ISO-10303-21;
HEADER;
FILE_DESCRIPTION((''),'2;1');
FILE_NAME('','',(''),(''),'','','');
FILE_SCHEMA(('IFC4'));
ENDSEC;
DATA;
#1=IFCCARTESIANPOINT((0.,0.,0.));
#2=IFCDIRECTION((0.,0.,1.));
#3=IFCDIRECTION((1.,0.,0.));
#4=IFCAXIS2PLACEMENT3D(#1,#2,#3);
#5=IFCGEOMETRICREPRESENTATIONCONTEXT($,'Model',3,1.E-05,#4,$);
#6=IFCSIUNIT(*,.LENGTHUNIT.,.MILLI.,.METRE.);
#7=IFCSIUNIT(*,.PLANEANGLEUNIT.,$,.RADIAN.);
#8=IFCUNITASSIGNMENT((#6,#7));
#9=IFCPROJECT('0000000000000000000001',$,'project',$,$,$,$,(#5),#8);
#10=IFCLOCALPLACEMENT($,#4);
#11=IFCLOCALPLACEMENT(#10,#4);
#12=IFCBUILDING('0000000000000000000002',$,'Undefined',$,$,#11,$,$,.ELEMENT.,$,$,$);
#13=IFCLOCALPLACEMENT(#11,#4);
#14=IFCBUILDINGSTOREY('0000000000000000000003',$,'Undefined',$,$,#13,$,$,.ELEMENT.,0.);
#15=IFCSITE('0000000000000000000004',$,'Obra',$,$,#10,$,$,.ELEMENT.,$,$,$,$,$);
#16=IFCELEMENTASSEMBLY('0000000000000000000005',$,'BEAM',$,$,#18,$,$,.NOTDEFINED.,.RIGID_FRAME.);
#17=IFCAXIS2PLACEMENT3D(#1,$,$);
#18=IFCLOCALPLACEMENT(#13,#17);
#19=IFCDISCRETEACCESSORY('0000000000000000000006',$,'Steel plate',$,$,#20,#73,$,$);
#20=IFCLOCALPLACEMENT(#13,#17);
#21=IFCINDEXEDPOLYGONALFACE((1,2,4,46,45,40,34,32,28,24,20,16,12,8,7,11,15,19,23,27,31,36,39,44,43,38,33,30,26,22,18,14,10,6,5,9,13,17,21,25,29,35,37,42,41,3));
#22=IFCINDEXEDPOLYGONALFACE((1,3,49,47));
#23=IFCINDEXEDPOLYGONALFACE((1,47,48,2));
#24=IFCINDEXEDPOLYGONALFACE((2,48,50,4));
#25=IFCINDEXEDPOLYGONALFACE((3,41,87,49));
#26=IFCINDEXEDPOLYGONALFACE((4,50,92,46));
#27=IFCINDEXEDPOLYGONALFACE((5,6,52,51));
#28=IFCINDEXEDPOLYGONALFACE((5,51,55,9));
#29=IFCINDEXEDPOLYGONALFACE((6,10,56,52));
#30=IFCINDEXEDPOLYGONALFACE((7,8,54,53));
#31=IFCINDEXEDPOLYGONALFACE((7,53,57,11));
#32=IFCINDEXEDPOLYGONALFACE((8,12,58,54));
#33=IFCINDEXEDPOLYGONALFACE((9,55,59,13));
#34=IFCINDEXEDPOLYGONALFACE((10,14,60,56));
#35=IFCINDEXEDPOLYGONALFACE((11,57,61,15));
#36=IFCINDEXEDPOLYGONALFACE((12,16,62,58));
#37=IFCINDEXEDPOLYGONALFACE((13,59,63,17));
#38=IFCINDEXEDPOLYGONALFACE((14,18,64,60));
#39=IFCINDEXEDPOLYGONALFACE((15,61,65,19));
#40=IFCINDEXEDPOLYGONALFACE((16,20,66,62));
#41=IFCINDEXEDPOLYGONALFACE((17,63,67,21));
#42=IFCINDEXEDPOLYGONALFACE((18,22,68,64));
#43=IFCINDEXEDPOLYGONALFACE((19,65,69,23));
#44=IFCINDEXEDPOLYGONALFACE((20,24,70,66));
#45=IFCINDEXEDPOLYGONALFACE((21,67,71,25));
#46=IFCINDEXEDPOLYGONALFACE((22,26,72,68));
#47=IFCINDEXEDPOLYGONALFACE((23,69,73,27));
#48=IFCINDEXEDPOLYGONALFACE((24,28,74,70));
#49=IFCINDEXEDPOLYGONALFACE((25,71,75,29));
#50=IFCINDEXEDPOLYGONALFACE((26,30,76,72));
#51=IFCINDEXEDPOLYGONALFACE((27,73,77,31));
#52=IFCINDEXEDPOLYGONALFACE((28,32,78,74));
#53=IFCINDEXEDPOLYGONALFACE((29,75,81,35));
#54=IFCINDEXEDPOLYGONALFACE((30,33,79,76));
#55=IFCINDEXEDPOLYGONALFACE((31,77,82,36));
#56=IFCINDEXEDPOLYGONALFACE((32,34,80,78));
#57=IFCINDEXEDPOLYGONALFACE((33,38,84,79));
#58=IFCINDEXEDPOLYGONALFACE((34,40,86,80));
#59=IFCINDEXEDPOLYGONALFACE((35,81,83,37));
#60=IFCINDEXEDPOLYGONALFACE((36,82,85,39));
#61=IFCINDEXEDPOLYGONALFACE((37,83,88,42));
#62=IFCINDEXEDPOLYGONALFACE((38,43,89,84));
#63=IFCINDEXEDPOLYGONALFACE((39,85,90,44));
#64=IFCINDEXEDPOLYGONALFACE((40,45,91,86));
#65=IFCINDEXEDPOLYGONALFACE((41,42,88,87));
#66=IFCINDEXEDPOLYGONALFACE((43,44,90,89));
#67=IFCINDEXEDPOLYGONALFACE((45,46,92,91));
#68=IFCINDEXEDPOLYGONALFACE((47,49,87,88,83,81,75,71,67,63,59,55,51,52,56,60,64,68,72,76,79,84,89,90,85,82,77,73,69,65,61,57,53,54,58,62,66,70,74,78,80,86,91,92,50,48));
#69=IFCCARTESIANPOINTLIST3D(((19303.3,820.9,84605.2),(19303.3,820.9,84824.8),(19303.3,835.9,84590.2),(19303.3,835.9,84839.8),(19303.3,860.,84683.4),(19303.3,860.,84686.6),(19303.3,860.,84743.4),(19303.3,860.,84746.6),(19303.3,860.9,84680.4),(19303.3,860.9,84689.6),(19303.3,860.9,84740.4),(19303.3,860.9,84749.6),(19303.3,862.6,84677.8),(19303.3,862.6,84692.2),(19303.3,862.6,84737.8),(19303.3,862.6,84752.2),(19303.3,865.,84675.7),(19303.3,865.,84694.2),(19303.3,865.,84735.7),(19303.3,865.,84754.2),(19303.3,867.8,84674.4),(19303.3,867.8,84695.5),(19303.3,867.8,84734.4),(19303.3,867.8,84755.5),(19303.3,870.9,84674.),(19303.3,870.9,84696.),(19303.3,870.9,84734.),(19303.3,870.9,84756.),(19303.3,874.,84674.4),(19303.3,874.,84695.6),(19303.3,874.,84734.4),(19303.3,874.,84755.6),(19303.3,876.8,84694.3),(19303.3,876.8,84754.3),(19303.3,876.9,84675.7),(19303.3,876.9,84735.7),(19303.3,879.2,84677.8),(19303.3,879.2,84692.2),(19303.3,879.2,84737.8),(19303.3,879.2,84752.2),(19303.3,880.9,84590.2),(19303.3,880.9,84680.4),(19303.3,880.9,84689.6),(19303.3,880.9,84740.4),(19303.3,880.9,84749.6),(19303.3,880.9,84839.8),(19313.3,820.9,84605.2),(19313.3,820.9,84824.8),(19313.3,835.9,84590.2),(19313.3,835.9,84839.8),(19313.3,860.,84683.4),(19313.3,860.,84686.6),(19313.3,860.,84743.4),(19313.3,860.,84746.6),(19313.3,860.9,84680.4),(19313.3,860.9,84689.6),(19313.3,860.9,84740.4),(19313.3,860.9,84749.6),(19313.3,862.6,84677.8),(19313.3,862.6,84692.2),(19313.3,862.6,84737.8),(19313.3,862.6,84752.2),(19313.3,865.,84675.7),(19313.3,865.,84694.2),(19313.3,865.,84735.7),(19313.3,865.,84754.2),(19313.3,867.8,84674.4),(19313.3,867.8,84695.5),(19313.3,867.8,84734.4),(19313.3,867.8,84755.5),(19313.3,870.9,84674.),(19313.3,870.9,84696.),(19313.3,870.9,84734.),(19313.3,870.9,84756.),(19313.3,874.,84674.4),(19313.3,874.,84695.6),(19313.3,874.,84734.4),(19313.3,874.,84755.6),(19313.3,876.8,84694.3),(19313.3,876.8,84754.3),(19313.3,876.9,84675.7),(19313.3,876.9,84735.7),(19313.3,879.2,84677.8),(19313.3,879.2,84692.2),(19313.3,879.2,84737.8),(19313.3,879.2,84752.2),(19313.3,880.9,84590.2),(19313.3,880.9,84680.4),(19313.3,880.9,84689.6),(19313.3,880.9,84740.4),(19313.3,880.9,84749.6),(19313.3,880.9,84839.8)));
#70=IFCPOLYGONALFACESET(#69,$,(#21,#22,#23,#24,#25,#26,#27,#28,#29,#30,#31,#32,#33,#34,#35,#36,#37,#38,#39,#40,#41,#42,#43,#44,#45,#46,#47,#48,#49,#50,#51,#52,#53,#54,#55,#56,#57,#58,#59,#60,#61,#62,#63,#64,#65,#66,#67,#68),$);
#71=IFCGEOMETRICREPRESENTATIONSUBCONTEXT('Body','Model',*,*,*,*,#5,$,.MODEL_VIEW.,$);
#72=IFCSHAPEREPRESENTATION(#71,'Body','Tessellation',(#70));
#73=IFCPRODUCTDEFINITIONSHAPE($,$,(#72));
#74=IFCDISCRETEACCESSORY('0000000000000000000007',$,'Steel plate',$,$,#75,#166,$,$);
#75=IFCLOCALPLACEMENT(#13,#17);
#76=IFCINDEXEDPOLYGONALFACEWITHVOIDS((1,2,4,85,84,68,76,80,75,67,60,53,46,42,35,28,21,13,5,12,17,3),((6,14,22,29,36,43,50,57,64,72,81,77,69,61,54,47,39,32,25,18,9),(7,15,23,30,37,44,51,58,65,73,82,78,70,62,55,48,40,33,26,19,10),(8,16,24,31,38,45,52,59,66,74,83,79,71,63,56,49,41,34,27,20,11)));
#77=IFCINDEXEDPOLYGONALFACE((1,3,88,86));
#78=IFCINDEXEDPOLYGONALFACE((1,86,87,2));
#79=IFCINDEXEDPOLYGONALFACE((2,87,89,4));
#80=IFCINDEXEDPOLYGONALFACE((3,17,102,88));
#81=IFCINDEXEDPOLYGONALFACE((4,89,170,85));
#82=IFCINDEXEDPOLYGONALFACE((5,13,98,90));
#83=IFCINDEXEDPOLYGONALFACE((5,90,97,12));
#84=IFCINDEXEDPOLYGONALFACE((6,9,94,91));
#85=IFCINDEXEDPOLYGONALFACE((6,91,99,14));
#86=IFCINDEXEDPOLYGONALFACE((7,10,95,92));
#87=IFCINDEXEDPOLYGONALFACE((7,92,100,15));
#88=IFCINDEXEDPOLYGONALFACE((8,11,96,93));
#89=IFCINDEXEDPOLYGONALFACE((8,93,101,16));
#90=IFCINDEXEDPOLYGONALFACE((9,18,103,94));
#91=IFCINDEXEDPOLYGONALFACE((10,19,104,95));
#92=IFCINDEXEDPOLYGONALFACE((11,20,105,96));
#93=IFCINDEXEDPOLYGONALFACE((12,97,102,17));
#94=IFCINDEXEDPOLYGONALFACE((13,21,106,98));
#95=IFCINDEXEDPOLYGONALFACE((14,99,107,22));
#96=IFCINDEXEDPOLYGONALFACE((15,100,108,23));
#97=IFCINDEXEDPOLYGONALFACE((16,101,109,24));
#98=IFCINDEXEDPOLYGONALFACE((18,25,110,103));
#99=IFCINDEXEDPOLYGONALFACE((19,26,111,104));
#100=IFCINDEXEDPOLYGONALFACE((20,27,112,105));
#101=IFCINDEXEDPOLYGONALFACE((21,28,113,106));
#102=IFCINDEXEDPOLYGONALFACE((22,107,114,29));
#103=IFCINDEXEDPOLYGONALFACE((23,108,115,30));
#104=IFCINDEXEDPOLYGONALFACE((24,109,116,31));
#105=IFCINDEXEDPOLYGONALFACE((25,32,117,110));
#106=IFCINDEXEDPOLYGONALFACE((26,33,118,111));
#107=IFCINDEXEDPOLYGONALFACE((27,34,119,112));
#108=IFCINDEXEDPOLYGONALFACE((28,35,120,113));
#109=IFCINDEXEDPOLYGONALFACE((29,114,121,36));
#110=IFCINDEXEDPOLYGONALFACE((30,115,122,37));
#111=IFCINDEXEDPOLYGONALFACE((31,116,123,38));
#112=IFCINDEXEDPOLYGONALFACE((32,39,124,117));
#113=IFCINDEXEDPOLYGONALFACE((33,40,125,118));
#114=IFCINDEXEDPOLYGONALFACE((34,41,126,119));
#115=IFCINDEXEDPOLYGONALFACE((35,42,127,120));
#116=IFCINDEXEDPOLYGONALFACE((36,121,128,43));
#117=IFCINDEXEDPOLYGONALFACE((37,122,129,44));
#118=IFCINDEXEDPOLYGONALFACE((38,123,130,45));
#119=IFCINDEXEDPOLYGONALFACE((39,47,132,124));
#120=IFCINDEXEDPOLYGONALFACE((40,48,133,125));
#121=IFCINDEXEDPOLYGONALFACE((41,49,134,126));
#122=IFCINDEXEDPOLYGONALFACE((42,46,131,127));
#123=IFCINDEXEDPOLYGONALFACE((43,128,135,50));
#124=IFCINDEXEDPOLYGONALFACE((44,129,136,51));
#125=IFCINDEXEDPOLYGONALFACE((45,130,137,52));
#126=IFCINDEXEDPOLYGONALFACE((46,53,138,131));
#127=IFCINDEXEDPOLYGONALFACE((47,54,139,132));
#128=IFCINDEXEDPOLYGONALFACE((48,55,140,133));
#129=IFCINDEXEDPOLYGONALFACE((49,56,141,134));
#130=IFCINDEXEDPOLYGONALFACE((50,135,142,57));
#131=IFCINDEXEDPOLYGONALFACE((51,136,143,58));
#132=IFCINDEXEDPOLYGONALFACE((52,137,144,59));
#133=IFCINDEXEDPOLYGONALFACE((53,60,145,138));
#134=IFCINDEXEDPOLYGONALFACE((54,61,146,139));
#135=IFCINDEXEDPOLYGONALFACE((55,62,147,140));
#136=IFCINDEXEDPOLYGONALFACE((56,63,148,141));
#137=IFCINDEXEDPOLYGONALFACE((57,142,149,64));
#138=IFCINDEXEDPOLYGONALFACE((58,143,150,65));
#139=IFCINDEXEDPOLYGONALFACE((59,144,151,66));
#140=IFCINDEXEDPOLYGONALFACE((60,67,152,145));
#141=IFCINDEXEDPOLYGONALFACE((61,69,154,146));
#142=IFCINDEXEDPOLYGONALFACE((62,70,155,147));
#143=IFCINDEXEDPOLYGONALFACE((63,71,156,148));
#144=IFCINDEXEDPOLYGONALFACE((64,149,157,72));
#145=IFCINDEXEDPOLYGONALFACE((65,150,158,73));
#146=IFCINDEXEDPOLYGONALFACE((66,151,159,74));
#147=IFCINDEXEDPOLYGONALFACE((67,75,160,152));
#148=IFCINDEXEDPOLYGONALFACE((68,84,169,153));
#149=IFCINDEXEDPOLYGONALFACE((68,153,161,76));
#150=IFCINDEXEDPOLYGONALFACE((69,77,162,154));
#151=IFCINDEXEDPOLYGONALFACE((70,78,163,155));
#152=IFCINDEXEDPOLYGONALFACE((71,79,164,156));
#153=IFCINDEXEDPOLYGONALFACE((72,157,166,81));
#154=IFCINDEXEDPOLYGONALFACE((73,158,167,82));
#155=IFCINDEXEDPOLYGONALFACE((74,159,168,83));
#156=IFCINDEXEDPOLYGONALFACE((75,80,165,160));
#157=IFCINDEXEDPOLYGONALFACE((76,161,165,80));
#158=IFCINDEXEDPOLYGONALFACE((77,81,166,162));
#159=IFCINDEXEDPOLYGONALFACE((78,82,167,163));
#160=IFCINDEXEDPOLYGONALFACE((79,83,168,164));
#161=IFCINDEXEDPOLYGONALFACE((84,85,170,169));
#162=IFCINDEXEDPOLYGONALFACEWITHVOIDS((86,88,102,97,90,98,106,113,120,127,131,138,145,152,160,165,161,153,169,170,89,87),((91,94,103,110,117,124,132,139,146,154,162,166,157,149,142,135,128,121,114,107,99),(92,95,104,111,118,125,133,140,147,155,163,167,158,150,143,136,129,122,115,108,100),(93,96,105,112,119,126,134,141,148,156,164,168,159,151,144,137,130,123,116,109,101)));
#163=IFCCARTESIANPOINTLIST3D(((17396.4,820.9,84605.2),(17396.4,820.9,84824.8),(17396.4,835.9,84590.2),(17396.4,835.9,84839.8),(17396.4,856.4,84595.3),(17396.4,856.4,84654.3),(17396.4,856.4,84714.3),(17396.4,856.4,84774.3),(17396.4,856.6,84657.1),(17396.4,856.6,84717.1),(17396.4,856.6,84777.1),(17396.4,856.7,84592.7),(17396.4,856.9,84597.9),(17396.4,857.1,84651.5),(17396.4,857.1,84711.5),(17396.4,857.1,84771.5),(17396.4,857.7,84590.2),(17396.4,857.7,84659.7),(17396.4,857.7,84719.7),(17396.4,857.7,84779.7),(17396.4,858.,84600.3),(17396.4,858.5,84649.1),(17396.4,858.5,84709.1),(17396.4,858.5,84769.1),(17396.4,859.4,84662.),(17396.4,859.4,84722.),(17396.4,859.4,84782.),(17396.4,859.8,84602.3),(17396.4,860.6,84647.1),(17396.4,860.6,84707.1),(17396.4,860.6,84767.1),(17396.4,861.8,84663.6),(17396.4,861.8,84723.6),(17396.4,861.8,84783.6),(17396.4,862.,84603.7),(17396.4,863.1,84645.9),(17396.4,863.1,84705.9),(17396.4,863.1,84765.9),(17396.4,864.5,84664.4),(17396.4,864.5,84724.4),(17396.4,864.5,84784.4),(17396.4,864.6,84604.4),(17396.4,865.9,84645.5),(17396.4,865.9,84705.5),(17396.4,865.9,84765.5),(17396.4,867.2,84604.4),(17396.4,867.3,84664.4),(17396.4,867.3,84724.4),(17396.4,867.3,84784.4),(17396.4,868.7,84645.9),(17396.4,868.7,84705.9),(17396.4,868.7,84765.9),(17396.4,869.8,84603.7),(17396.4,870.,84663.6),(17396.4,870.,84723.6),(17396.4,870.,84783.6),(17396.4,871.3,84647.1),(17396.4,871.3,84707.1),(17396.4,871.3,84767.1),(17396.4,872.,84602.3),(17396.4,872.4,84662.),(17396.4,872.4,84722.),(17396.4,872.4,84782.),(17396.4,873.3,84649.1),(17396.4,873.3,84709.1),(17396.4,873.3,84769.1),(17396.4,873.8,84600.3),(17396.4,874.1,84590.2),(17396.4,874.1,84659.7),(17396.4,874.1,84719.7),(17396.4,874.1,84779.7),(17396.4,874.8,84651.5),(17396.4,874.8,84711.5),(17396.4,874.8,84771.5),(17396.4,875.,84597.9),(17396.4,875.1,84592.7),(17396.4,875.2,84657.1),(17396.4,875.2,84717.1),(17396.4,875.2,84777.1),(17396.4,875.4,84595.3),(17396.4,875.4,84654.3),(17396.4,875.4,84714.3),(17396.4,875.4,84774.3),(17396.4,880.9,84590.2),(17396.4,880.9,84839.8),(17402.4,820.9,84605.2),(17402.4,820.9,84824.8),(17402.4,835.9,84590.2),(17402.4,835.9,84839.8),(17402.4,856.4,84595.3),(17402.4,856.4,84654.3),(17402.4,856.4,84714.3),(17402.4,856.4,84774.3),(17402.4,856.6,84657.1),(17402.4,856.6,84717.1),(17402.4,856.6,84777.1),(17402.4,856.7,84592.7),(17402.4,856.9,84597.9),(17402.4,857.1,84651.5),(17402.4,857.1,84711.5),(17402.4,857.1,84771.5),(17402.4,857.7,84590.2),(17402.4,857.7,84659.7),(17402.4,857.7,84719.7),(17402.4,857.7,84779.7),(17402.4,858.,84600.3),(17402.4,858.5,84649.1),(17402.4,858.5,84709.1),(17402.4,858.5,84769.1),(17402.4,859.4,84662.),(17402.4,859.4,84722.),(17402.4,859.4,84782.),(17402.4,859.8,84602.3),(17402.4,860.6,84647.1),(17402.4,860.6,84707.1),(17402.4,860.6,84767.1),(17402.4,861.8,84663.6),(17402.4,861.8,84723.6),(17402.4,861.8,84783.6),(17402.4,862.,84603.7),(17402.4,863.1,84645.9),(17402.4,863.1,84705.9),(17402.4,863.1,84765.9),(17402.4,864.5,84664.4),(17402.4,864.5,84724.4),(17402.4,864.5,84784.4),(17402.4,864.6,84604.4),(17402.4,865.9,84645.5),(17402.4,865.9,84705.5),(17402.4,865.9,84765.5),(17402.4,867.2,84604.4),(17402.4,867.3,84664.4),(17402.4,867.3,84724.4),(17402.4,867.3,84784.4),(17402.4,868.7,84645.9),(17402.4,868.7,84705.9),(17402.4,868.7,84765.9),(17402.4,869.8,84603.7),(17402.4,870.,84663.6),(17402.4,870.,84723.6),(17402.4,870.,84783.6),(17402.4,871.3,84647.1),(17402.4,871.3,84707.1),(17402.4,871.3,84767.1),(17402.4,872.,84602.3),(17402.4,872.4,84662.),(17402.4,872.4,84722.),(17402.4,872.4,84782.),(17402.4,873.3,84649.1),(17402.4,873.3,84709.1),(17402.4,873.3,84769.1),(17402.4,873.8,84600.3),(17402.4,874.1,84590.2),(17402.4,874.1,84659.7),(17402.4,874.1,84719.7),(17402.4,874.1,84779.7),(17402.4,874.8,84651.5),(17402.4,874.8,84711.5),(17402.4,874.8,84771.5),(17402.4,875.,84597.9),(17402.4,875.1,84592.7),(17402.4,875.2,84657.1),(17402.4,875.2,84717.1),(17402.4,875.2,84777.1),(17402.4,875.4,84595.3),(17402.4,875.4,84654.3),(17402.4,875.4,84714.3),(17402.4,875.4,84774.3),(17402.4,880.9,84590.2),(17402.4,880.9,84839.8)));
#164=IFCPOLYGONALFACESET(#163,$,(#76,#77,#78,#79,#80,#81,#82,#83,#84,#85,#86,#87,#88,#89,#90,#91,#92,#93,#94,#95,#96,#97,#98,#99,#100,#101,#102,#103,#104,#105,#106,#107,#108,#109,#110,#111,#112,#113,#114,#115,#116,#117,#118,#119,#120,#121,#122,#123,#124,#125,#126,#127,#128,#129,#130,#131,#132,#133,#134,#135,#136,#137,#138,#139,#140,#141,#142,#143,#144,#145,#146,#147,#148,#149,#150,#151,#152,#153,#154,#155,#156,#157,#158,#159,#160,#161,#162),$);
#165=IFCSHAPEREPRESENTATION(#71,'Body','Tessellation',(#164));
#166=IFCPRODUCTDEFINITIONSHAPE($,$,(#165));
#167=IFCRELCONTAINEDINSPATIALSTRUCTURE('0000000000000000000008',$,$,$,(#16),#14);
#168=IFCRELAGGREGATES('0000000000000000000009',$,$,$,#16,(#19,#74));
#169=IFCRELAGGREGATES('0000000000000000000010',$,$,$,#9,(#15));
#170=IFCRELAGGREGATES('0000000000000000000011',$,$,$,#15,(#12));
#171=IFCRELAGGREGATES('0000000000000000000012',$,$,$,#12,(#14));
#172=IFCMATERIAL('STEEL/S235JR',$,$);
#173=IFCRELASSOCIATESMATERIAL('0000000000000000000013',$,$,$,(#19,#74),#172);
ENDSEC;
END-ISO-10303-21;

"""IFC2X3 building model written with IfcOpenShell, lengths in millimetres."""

from ifc_helpers import new_model, si_unit, frame, origin_with_axes, origin_2d_with_axis, place, context, subcontext, project, spatial, polyline, circle, outline, extrude, source, transform, mapped, material, element, aggregate, save


model = new_model("IFC2X3")

# Units and contexts
model_context = context("Model", 3, precision=1e-05, world=origin_with_axes())
body_context = subcontext(model_context, "Body", "Model", "MODEL_VIEW")
ifc_project = project(units=[si_unit("LENGTHUNIT", "METRE", prefix="MILLI"), si_unit("PLANEANGLEUNIT", "RADIAN")], contexts=[model_context])

# Site, building, storey
site_placement = place(None, origin_with_axes())
site = spatial("IfcSite", under=ifc_project, at=site_placement, Name="Obra", CompositionType="ELEMENT")
building_placement = place(site_placement, origin_with_axes())
building = spatial("IfcBuilding", under=site, at=building_placement, Name="Undefined", CompositionType="ELEMENT")
storey_placement = place(building_placement, origin_with_axes())
storey = spatial("IfcBuildingStorey", under=building, at=storey_placement, Name="Undefined", CompositionType="ELEMENT", Elevation=0.0)

# Shared definitions
ifc_material_1 = material(Name="STEEL/S235JR")

# Element assembly, discrete accessories, openings
shared_shape_1 = source(origin_with_axes(), body_context, "Body", "SweptSolid", [
    extrude(circle(Radius=9.5, at=origin_2d_with_axis()), frame((0.0, -9.8, 0.0), z_axis=(0.0, 1.0, 0.0), x_axis=(1.0, 0.0, 0.0)), (0.0, 0.0, 1.0), 6.2),
])
shared_shape_2 = source(origin_with_axes(), body_context, "Body", "SweptSolid", [
    extrude(circle(Radius=11.0, at=origin_2d_with_axis()), frame((0.0, -13.4, 0.0), z_axis=(0.0, 1.0, 0.0), x_axis=(1.0, 0.0, 0.0)), (0.0, 0.0, 1.0), 10.2),
])
assembly_1_placement = place(storey_placement, origin_with_axes())
assembly_1 = element("IfcElementAssembly", 1, at=assembly_1_placement, inside=storey, Name="BEAM", AssemblyPlace="NOTDEFINED", PredefinedType="RIGID_FRAME")
discrete_accessory_1_placement = place(assembly_1_placement, frame((19308.3, 880.9, 84590.2), z_axis=(-1.0, 0.0, 0.0), x_axis=(0.0, -1.0, 0.0)))
discrete_accessory_1 = element("IfcDiscreteAccessory", 2, at=discrete_accessory_1_placement, material=ifc_material_1, Name="Steel plate", context=body_context, shape_type="SweptSolid", body=[
    extrude(outline(polyline([(0.0, 0.0), (45.0, 0.0), (60.0, 15.0), (60.0, 234.6), (45.0, 249.6), (0.0, 249.6), (0.0, 0.0)])), frame((0.0, 0.0, -5.0), z_axis=(0.0, 0.0, 1.0), x_axis=(1.0, 0.0, 0.0)), (0.0, 0.0, 1.0), 10.0),
])
opening_1_placement = place(assembly_1_placement, frame((19300.0, 830.9, 84850.0), z_axis=(0.0, 1.0, 0.0), x_axis=(0.0, 0.0, -1.0)))
element("IfcOpeningElement", 3, at=opening_1_placement, cuts=discrete_accessory_1, ObjectType="Opening", context=body_context, shape_type="MappedRepresentation", body=[
    mapped(shared_shape_2, transform((105.0, 0.0, 40.0))),
    mapped(shared_shape_2, transform((165.0, 0.0, 40.0))),
])
discrete_accessory_2_placement = place(assembly_1_placement, frame((17399.4, 880.9, 84590.2), z_axis=(-1.0, 0.0, 0.0), x_axis=(0.0, -1.0, 0.0)))
discrete_accessory_2 = element("IfcDiscreteAccessory", 4, at=discrete_accessory_2_placement, material=ifc_material_1, Name="Steel plate", context=body_context, shape_type="SweptSolid", body=[
    extrude(outline(polyline([(0.0, 0.0), (45.0, 0.0), (60.0, 15.0), (60.0, 234.6), (45.0, 249.6), (0.0, 249.6), (0.0, 0.0)])), frame((0.0, 0.0, -3.0), z_axis=(0.0, 0.0, 1.0), x_axis=(1.0, 0.0, 0.0)), (0.0, 0.0, 1.0), 6.0),
])
opening_2_placement = place(assembly_1_placement, frame((17392.7, 830.9, 84850.0), z_axis=(0.0, 1.0, 0.0), x_axis=(0.0, 0.0, -1.0)))
element("IfcOpeningElement", 5, at=opening_2_placement, cuts=discrete_accessory_2, ObjectType="Opening", context=body_context, shape_type="MappedRepresentation", body=[
    mapped(shared_shape_1, transform((75.0, 0.0, 35.0))),
    mapped(shared_shape_1, transform((135.0, 0.0, 35.0))),
    mapped(shared_shape_1, transform((195.0, 0.0, 35.0))),
    mapped(shared_shape_1, transform((255.0, 0.0, 35.0))),
])
aggregate(assembly_1, [discrete_accessory_1, discrete_accessory_2])

save(model, "model.ifc")
